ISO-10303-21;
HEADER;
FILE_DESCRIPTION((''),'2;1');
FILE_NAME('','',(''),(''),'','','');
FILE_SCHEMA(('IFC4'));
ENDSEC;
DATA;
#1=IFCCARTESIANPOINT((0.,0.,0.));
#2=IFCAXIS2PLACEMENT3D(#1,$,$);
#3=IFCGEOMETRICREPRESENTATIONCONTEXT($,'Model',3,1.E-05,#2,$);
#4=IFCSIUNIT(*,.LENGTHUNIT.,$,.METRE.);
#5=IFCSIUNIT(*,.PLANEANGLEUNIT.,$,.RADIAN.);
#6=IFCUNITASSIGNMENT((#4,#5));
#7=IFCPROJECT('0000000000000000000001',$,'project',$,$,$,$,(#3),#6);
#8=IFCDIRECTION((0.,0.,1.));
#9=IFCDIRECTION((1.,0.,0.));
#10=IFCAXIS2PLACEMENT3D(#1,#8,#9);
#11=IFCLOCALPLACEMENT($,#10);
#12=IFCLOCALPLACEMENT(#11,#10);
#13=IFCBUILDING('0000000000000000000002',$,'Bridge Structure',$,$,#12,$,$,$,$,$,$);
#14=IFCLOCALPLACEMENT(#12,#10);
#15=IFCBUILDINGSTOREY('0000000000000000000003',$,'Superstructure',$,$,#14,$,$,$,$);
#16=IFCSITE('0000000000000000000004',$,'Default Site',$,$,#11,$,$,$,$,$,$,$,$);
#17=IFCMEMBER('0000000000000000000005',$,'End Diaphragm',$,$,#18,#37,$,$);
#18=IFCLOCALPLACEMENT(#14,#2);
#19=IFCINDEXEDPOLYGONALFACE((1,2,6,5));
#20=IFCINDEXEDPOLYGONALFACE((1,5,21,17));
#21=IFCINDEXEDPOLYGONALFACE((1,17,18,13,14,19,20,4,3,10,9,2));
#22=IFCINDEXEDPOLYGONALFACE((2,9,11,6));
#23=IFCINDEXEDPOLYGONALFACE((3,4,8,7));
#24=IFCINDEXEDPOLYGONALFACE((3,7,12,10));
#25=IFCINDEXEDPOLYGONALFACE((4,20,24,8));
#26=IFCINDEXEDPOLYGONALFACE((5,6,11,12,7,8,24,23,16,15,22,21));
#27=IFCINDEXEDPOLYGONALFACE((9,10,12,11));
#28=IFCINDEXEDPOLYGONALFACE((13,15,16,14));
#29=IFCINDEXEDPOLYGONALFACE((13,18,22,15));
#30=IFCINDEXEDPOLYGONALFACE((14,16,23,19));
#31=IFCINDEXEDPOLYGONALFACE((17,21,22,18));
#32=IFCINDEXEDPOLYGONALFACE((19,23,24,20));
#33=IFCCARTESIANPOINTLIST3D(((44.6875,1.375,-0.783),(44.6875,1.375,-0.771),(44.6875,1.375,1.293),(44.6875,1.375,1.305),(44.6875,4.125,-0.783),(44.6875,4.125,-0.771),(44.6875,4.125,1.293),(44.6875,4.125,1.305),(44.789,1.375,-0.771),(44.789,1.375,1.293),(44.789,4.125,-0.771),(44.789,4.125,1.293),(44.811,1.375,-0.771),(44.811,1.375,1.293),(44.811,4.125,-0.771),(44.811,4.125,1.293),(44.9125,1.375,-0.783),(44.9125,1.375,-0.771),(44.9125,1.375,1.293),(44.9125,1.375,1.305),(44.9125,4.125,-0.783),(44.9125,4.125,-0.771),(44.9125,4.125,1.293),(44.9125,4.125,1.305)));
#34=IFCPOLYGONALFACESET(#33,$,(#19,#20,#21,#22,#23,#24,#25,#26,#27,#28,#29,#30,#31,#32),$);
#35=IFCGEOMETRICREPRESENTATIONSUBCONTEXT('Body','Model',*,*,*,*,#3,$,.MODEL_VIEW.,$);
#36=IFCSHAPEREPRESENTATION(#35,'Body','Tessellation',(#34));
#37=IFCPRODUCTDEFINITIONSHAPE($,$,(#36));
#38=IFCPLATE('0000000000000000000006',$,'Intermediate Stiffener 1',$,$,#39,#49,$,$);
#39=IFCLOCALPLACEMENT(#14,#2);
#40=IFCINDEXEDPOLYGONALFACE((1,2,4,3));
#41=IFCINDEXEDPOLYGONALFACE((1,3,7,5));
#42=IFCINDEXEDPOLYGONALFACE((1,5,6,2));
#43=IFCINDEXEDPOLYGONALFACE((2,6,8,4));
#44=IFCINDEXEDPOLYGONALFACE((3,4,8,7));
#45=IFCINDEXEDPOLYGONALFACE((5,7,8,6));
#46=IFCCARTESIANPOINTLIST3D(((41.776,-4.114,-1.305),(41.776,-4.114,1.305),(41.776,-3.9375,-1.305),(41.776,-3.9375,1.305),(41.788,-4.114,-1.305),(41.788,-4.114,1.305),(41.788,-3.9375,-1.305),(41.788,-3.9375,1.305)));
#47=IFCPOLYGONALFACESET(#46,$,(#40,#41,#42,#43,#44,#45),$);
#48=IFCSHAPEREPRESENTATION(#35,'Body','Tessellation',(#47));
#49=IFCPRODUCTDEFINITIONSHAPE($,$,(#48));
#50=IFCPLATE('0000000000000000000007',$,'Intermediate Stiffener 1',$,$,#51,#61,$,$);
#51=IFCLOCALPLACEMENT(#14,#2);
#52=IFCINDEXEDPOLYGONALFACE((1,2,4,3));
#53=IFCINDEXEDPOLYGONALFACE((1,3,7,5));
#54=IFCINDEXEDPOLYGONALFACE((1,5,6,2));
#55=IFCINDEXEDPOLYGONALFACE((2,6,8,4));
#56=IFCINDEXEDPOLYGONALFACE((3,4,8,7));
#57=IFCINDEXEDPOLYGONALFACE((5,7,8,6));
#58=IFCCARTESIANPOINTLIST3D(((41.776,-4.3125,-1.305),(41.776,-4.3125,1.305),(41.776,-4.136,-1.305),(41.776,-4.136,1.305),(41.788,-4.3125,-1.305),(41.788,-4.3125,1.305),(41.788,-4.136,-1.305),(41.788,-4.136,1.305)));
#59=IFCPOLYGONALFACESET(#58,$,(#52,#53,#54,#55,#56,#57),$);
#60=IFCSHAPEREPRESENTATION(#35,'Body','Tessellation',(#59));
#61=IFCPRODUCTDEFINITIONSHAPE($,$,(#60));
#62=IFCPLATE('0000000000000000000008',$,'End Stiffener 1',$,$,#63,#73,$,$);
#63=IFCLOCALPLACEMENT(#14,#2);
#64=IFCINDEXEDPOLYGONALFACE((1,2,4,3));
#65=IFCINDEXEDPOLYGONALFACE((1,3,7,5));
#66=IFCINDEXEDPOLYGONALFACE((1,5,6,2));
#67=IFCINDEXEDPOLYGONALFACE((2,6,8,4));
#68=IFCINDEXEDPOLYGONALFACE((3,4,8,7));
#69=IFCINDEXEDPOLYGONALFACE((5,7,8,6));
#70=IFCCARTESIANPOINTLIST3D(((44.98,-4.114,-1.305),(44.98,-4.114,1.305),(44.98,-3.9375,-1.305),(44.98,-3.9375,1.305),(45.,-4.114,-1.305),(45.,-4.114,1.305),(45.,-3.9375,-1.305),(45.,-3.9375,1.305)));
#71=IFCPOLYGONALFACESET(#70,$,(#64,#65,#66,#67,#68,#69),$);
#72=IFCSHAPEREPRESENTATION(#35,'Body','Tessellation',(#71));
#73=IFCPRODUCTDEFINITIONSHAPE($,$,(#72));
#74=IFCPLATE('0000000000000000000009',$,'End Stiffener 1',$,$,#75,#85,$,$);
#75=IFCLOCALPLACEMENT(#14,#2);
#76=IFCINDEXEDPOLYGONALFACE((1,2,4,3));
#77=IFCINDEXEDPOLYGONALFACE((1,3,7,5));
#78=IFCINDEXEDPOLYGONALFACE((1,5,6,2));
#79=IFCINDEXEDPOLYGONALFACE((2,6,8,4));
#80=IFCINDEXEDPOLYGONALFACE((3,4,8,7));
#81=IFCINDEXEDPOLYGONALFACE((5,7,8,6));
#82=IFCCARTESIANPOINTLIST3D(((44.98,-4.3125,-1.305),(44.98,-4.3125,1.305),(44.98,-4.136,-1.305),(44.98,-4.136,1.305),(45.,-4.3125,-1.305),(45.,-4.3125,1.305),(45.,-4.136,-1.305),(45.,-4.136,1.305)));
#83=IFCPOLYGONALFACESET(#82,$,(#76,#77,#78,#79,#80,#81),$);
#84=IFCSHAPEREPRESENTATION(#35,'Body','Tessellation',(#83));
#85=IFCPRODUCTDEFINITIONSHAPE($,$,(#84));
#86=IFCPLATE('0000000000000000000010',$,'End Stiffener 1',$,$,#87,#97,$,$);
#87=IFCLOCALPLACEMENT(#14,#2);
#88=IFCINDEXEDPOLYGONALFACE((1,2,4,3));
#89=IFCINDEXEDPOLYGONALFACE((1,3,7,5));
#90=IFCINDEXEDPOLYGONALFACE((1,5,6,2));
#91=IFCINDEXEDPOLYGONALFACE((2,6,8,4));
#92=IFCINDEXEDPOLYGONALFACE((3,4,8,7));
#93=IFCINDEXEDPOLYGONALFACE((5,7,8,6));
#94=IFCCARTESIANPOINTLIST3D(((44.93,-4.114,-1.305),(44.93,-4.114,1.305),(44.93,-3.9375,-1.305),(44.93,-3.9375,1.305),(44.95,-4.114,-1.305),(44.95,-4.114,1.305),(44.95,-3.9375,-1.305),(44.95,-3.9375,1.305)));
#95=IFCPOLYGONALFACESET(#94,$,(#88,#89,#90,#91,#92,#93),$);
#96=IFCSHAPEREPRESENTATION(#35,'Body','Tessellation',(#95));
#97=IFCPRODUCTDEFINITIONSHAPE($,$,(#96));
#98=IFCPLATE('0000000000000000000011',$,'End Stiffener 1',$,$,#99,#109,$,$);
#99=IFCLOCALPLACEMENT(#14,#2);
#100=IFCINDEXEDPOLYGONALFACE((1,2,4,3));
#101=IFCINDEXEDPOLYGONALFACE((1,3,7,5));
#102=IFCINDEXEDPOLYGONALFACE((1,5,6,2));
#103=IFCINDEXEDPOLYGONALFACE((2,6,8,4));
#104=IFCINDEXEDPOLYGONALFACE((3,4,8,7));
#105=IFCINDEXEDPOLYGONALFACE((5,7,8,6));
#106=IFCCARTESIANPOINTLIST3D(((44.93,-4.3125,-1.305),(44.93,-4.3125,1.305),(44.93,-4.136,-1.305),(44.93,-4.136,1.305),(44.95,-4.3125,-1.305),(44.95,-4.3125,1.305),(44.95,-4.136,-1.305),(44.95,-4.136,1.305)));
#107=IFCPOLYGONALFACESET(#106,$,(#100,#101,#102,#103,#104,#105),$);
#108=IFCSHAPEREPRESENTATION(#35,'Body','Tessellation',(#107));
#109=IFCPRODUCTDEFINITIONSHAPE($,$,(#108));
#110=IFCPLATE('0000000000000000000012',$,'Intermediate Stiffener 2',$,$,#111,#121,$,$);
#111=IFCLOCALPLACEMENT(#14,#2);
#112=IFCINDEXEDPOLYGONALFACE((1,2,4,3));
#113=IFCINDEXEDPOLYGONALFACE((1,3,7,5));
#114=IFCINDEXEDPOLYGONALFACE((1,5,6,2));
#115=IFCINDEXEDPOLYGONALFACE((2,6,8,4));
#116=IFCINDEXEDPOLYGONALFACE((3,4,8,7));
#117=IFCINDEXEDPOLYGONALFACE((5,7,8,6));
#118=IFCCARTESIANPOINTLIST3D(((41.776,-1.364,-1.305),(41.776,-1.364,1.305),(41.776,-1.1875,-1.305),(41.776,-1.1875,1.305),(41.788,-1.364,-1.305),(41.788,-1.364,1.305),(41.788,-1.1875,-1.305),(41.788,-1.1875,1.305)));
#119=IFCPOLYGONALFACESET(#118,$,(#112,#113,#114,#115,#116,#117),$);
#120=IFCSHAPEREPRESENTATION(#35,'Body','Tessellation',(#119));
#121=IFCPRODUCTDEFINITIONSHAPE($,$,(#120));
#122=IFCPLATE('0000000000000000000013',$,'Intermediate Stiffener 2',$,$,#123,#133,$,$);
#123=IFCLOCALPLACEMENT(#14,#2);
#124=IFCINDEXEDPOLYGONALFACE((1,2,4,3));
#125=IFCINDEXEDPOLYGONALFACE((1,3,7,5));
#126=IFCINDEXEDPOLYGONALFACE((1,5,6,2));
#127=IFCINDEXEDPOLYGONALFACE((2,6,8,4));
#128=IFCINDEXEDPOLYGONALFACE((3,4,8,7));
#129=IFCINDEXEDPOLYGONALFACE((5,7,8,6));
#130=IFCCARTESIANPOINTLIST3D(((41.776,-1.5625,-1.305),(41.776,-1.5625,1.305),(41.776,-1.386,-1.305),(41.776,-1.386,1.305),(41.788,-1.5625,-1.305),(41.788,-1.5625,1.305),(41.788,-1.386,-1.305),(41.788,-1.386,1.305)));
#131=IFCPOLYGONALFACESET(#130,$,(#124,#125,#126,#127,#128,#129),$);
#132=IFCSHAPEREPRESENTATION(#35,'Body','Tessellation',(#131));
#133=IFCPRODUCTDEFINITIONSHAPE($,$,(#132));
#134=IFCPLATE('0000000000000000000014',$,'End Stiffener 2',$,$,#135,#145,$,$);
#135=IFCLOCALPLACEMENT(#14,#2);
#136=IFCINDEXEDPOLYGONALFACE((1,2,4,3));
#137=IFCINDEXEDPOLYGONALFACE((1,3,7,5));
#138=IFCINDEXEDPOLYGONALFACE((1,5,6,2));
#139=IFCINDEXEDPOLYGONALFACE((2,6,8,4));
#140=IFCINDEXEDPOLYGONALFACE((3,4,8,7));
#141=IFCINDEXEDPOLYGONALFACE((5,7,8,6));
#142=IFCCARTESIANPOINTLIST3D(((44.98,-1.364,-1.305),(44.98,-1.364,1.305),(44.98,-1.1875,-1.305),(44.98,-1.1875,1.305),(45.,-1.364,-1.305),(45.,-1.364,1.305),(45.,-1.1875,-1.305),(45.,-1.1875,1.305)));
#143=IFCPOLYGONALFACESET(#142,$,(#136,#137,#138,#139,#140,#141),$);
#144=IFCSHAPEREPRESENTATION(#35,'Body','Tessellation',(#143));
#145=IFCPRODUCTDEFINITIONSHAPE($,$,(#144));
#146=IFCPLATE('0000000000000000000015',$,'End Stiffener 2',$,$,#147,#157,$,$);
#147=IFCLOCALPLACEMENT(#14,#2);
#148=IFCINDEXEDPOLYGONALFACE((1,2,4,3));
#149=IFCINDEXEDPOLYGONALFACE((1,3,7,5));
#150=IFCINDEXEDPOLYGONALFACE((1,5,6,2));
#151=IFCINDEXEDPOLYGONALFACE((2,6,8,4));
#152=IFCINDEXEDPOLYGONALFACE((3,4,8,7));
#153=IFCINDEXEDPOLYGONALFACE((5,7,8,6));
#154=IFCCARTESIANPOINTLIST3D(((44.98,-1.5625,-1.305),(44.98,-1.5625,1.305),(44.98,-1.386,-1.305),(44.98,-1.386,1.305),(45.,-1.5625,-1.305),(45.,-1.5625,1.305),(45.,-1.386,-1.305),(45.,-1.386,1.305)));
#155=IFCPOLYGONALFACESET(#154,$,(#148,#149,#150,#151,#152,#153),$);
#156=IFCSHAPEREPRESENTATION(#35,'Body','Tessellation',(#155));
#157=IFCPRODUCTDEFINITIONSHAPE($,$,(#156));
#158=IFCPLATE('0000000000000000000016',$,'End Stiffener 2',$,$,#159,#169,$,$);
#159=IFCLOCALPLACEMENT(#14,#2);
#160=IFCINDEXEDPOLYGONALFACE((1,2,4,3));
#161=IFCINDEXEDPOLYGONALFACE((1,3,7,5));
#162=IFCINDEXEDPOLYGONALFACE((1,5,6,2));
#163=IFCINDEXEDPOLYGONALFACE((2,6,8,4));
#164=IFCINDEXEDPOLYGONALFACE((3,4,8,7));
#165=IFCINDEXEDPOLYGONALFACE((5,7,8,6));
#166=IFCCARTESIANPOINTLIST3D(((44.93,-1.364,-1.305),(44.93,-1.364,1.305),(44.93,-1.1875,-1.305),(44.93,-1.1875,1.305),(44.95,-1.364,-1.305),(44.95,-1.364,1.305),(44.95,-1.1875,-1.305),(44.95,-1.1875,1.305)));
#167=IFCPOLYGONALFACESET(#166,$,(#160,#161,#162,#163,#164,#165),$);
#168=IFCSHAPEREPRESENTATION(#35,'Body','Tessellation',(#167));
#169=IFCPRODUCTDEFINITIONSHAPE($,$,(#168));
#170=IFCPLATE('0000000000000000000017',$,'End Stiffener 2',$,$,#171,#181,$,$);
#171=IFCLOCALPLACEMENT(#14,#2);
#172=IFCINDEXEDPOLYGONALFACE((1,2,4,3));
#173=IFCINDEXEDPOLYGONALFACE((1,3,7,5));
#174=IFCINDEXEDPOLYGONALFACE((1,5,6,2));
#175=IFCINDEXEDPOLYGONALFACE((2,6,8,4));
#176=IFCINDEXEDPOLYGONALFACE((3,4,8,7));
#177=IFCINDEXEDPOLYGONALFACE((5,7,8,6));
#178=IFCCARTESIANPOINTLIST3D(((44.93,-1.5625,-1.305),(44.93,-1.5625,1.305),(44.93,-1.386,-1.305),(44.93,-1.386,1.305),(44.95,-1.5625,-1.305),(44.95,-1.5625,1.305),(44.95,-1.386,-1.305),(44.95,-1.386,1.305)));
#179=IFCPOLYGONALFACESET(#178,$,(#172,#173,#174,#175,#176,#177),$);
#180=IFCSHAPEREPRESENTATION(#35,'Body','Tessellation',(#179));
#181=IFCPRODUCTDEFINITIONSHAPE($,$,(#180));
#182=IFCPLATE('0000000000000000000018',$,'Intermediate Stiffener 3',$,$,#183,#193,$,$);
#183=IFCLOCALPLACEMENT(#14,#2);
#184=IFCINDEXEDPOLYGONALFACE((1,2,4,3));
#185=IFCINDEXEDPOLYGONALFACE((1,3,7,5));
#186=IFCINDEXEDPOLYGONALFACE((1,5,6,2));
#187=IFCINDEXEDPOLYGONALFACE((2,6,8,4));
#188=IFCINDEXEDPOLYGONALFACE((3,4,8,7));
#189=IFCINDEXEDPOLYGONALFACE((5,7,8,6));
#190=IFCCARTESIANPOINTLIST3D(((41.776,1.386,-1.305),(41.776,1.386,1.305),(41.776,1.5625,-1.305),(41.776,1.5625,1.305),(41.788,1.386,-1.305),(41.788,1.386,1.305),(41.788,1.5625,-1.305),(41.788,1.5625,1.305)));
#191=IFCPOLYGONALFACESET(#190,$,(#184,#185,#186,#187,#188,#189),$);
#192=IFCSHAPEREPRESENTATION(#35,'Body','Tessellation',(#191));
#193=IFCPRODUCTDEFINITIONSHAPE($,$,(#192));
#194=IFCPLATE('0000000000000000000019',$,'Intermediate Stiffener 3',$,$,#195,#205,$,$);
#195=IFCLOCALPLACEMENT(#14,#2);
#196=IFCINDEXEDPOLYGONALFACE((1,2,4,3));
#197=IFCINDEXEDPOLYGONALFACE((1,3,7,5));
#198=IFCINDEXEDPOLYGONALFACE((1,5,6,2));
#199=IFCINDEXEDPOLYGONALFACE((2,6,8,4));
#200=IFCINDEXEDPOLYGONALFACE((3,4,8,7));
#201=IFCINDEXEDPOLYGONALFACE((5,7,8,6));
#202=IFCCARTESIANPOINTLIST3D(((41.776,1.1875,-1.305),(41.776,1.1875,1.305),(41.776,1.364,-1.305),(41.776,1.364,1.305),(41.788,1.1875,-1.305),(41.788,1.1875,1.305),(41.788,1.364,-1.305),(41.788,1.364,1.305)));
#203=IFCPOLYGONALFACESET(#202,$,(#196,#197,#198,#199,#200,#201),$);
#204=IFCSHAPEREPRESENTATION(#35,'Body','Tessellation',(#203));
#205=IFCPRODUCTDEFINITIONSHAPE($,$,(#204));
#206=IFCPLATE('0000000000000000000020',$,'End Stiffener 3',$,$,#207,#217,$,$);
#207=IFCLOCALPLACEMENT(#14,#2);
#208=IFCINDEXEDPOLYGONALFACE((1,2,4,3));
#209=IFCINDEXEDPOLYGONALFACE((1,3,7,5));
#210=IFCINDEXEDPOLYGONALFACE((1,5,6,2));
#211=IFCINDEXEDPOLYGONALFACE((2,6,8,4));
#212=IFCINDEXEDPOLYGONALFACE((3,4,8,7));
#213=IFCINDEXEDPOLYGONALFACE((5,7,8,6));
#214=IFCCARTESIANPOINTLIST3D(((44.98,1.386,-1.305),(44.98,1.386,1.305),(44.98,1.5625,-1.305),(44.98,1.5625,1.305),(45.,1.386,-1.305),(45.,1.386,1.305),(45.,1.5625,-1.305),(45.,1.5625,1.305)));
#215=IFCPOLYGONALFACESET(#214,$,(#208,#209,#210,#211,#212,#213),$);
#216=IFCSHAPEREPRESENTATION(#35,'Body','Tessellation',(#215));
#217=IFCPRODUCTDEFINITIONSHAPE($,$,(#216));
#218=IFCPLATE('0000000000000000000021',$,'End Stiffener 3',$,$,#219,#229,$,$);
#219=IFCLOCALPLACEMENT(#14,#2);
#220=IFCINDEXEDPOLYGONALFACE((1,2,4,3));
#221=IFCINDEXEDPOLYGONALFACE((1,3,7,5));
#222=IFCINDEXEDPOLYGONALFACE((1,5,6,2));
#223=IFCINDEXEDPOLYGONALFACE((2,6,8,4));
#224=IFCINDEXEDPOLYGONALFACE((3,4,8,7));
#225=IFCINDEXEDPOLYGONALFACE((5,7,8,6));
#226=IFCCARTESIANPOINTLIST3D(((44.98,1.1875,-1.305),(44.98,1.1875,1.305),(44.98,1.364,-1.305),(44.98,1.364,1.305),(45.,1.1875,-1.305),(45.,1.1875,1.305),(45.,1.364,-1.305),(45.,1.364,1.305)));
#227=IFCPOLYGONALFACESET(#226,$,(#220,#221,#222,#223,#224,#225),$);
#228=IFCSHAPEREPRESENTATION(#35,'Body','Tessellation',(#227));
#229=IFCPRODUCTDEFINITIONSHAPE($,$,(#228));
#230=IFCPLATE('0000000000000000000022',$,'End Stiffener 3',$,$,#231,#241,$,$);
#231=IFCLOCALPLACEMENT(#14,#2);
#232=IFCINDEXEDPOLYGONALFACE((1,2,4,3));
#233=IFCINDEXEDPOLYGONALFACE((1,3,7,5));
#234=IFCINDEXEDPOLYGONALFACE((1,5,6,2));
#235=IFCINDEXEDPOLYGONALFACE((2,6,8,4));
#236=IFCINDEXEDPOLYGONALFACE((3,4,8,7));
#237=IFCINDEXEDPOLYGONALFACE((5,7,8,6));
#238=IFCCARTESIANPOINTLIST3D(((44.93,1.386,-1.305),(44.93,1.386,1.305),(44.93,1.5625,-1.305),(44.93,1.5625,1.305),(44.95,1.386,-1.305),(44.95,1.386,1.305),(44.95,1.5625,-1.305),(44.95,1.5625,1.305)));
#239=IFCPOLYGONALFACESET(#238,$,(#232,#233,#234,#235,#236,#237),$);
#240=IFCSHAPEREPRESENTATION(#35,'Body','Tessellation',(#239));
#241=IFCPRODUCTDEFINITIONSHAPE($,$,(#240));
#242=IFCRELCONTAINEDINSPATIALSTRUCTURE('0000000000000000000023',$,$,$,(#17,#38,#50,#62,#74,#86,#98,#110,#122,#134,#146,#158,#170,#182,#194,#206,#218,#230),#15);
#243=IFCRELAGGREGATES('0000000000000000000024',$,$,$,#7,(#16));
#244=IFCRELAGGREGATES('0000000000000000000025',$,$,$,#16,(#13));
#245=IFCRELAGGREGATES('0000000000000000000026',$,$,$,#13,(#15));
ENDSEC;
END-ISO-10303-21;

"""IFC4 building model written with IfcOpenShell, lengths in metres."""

from ifc_helpers import new_model, si_unit, frame, origin, origin_with_axes, origin_2d_with_axis, place, context, subcontext, project, spatial, rectangle, i_section, extrude, element, save


model = new_model("IFC4")

# Units and contexts
model_context = context("Model", 3, precision=1e-05, world=origin())
body_context = subcontext(model_context, "Body", "Model", "MODEL_VIEW")
ifc_project = project(units=[si_unit("LENGTHUNIT", "METRE"), si_unit("PLANEANGLEUNIT", "RADIAN")], contexts=[model_context])

# Site, building, storey
site_placement = place(None, origin_with_axes())
site = spatial("IfcSite", under=ifc_project, at=site_placement, Name="Default Site")
building_placement = place(site_placement, origin_with_axes())
building = spatial("IfcBuilding", under=site, at=building_placement, Name="Bridge Structure")
storey_placement = place(building_placement, origin_with_axes())
storey = spatial("IfcBuildingStorey", under=building, at=storey_placement, Name="Superstructure")

# Member
for number, where, z_axis, x_axis, name in (
    (1, (44.8, 1.375, 0.261), (0.0, 1.0, 0.0), (-1.0, 0.0, 0.0), "End Diaphragm"),
):
    element("IfcMember", number, at=place(storey_placement, frame(where, z_axis=z_axis, x_axis=x_axis)), inside=storey, Name=name, context=body_context, shape_type="SweptSolid", body=[
        extrude(i_section(OverallWidth=0.225, OverallDepth=2.088, WebThickness=0.022, FlangeThickness=0.012, at=origin_2d_with_axis()), origin_with_axes(), (0.0, 0.0, 1.0), 2.75),
    ])

# Plates
for number, where, z_axis, x_axis, name in (
    (2, (41.782, -4.0258, -1.305), (0.0, 0.0, 1.0), (1.0, 0.0, 0.0), "Intermediate Stiffener 1"),
    (3, (41.782, -4.2243, -1.305), (0.0, 0.0, 1.0), (1.0, 0.0, 0.0), "Intermediate Stiffener 1"),
):
    element("IfcPlate", number, at=place(storey_placement, frame(where, z_axis=z_axis, x_axis=x_axis)), inside=storey, Name=name, context=body_context, shape_type="SweptSolid", body=[
        extrude(rectangle(XDim=0.012, YDim=0.1765, at=origin_2d_with_axis()), origin_with_axes(), (0.0, 0.0, 1.0), 2.61),
    ])
for number, where, z_axis, x_axis, name in (
    (4, (44.99, -4.0258, -1.305), (0.0, 0.0, 1.0), (1.0, 0.0, 0.0), "End Stiffener 1"),
    (5, (44.99, -4.2243, -1.305), (0.0, 0.0, 1.0), (1.0, 0.0, 0.0), "End Stiffener 1"),
    (6, (44.94, -4.0258, -1.305), (0.0, 0.0, 1.0), (1.0, 0.0, 0.0), "End Stiffener 1"),
    (7, (44.94, -4.2243, -1.305), (0.0, 0.0, 1.0), (1.0, 0.0, 0.0), "End Stiffener 1"),
):
    element("IfcPlate", number, at=place(storey_placement, frame(where, z_axis=z_axis, x_axis=x_axis)), inside=storey, Name=name, context=body_context, shape_type="SweptSolid", body=[
        extrude(rectangle(XDim=0.02, YDim=0.1765, at=origin_2d_with_axis()), origin_with_axes(), (0.0, 0.0, 1.0), 2.61),
    ])
for number, where, z_axis, x_axis, name in (
    (8, (41.782, -1.2757, -1.305), (0.0, 0.0, 1.0), (1.0, 0.0, 0.0), "Intermediate Stiffener 2"),
    (9, (41.782, -1.4743, -1.305), (0.0, 0.0, 1.0), (1.0, 0.0, 0.0), "Intermediate Stiffener 2"),
):
    element("IfcPlate", number, at=place(storey_placement, frame(where, z_axis=z_axis, x_axis=x_axis)), inside=storey, Name=name, context=body_context, shape_type="SweptSolid", body=[
        extrude(rectangle(XDim=0.012, YDim=0.1765, at=origin_2d_with_axis()), origin_with_axes(), (0.0, 0.0, 1.0), 2.61),
    ])
for number, where, z_axis, x_axis, name in (
    (10, (44.99, -1.2757, -1.305), (0.0, 0.0, 1.0), (1.0, 0.0, 0.0), "End Stiffener 2"),
    (11, (44.99, -1.4743, -1.305), (0.0, 0.0, 1.0), (1.0, 0.0, 0.0), "End Stiffener 2"),
    (12, (44.94, -1.2757, -1.305), (0.0, 0.0, 1.0), (1.0, 0.0, 0.0), "End Stiffener 2"),
    (13, (44.94, -1.4743, -1.305), (0.0, 0.0, 1.0), (1.0, 0.0, 0.0), "End Stiffener 2"),
):
    element("IfcPlate", number, at=place(storey_placement, frame(where, z_axis=z_axis, x_axis=x_axis)), inside=storey, Name=name, context=body_context, shape_type="SweptSolid", body=[
        extrude(rectangle(XDim=0.02, YDim=0.1765, at=origin_2d_with_axis()), origin_with_axes(), (0.0, 0.0, 1.0), 2.61),
    ])
for number, where, z_axis, x_axis, name in (
    (14, (41.782, 1.4743, -1.305), (0.0, 0.0, 1.0), (1.0, 0.0, 0.0), "Intermediate Stiffener 3"),
    (15, (41.782, 1.2757, -1.305), (0.0, 0.0, 1.0), (1.0, 0.0, 0.0), "Intermediate Stiffener 3"),
):
    element("IfcPlate", number, at=place(storey_placement, frame(where, z_axis=z_axis, x_axis=x_axis)), inside=storey, Name=name, context=body_context, shape_type="SweptSolid", body=[
        extrude(rectangle(XDim=0.012, YDim=0.1765, at=origin_2d_with_axis()), origin_with_axes(), (0.0, 0.0, 1.0), 2.61),
    ])
for number, where, z_axis, x_axis, name in (
    (16, (44.99, 1.4743, -1.305), (0.0, 0.0, 1.0), (1.0, 0.0, 0.0), "End Stiffener 3"),
    (17, (44.99, 1.2757, -1.305), (0.0, 0.0, 1.0), (1.0, 0.0, 0.0), "End Stiffener 3"),
    (18, (44.94, 1.4743, -1.305), (0.0, 0.0, 1.0), (1.0, 0.0, 0.0), "End Stiffener 3"),
):
    element("IfcPlate", number, at=place(storey_placement, frame(where, z_axis=z_axis, x_axis=x_axis)), inside=storey, Name=name, context=body_context, shape_type="SweptSolid", body=[
        extrude(rectangle(XDim=0.02, YDim=0.1765, at=origin_2d_with_axis()), origin_with_axes(), (0.0, 0.0, 1.0), 2.61),
    ])

save(model, "model.ifc")
